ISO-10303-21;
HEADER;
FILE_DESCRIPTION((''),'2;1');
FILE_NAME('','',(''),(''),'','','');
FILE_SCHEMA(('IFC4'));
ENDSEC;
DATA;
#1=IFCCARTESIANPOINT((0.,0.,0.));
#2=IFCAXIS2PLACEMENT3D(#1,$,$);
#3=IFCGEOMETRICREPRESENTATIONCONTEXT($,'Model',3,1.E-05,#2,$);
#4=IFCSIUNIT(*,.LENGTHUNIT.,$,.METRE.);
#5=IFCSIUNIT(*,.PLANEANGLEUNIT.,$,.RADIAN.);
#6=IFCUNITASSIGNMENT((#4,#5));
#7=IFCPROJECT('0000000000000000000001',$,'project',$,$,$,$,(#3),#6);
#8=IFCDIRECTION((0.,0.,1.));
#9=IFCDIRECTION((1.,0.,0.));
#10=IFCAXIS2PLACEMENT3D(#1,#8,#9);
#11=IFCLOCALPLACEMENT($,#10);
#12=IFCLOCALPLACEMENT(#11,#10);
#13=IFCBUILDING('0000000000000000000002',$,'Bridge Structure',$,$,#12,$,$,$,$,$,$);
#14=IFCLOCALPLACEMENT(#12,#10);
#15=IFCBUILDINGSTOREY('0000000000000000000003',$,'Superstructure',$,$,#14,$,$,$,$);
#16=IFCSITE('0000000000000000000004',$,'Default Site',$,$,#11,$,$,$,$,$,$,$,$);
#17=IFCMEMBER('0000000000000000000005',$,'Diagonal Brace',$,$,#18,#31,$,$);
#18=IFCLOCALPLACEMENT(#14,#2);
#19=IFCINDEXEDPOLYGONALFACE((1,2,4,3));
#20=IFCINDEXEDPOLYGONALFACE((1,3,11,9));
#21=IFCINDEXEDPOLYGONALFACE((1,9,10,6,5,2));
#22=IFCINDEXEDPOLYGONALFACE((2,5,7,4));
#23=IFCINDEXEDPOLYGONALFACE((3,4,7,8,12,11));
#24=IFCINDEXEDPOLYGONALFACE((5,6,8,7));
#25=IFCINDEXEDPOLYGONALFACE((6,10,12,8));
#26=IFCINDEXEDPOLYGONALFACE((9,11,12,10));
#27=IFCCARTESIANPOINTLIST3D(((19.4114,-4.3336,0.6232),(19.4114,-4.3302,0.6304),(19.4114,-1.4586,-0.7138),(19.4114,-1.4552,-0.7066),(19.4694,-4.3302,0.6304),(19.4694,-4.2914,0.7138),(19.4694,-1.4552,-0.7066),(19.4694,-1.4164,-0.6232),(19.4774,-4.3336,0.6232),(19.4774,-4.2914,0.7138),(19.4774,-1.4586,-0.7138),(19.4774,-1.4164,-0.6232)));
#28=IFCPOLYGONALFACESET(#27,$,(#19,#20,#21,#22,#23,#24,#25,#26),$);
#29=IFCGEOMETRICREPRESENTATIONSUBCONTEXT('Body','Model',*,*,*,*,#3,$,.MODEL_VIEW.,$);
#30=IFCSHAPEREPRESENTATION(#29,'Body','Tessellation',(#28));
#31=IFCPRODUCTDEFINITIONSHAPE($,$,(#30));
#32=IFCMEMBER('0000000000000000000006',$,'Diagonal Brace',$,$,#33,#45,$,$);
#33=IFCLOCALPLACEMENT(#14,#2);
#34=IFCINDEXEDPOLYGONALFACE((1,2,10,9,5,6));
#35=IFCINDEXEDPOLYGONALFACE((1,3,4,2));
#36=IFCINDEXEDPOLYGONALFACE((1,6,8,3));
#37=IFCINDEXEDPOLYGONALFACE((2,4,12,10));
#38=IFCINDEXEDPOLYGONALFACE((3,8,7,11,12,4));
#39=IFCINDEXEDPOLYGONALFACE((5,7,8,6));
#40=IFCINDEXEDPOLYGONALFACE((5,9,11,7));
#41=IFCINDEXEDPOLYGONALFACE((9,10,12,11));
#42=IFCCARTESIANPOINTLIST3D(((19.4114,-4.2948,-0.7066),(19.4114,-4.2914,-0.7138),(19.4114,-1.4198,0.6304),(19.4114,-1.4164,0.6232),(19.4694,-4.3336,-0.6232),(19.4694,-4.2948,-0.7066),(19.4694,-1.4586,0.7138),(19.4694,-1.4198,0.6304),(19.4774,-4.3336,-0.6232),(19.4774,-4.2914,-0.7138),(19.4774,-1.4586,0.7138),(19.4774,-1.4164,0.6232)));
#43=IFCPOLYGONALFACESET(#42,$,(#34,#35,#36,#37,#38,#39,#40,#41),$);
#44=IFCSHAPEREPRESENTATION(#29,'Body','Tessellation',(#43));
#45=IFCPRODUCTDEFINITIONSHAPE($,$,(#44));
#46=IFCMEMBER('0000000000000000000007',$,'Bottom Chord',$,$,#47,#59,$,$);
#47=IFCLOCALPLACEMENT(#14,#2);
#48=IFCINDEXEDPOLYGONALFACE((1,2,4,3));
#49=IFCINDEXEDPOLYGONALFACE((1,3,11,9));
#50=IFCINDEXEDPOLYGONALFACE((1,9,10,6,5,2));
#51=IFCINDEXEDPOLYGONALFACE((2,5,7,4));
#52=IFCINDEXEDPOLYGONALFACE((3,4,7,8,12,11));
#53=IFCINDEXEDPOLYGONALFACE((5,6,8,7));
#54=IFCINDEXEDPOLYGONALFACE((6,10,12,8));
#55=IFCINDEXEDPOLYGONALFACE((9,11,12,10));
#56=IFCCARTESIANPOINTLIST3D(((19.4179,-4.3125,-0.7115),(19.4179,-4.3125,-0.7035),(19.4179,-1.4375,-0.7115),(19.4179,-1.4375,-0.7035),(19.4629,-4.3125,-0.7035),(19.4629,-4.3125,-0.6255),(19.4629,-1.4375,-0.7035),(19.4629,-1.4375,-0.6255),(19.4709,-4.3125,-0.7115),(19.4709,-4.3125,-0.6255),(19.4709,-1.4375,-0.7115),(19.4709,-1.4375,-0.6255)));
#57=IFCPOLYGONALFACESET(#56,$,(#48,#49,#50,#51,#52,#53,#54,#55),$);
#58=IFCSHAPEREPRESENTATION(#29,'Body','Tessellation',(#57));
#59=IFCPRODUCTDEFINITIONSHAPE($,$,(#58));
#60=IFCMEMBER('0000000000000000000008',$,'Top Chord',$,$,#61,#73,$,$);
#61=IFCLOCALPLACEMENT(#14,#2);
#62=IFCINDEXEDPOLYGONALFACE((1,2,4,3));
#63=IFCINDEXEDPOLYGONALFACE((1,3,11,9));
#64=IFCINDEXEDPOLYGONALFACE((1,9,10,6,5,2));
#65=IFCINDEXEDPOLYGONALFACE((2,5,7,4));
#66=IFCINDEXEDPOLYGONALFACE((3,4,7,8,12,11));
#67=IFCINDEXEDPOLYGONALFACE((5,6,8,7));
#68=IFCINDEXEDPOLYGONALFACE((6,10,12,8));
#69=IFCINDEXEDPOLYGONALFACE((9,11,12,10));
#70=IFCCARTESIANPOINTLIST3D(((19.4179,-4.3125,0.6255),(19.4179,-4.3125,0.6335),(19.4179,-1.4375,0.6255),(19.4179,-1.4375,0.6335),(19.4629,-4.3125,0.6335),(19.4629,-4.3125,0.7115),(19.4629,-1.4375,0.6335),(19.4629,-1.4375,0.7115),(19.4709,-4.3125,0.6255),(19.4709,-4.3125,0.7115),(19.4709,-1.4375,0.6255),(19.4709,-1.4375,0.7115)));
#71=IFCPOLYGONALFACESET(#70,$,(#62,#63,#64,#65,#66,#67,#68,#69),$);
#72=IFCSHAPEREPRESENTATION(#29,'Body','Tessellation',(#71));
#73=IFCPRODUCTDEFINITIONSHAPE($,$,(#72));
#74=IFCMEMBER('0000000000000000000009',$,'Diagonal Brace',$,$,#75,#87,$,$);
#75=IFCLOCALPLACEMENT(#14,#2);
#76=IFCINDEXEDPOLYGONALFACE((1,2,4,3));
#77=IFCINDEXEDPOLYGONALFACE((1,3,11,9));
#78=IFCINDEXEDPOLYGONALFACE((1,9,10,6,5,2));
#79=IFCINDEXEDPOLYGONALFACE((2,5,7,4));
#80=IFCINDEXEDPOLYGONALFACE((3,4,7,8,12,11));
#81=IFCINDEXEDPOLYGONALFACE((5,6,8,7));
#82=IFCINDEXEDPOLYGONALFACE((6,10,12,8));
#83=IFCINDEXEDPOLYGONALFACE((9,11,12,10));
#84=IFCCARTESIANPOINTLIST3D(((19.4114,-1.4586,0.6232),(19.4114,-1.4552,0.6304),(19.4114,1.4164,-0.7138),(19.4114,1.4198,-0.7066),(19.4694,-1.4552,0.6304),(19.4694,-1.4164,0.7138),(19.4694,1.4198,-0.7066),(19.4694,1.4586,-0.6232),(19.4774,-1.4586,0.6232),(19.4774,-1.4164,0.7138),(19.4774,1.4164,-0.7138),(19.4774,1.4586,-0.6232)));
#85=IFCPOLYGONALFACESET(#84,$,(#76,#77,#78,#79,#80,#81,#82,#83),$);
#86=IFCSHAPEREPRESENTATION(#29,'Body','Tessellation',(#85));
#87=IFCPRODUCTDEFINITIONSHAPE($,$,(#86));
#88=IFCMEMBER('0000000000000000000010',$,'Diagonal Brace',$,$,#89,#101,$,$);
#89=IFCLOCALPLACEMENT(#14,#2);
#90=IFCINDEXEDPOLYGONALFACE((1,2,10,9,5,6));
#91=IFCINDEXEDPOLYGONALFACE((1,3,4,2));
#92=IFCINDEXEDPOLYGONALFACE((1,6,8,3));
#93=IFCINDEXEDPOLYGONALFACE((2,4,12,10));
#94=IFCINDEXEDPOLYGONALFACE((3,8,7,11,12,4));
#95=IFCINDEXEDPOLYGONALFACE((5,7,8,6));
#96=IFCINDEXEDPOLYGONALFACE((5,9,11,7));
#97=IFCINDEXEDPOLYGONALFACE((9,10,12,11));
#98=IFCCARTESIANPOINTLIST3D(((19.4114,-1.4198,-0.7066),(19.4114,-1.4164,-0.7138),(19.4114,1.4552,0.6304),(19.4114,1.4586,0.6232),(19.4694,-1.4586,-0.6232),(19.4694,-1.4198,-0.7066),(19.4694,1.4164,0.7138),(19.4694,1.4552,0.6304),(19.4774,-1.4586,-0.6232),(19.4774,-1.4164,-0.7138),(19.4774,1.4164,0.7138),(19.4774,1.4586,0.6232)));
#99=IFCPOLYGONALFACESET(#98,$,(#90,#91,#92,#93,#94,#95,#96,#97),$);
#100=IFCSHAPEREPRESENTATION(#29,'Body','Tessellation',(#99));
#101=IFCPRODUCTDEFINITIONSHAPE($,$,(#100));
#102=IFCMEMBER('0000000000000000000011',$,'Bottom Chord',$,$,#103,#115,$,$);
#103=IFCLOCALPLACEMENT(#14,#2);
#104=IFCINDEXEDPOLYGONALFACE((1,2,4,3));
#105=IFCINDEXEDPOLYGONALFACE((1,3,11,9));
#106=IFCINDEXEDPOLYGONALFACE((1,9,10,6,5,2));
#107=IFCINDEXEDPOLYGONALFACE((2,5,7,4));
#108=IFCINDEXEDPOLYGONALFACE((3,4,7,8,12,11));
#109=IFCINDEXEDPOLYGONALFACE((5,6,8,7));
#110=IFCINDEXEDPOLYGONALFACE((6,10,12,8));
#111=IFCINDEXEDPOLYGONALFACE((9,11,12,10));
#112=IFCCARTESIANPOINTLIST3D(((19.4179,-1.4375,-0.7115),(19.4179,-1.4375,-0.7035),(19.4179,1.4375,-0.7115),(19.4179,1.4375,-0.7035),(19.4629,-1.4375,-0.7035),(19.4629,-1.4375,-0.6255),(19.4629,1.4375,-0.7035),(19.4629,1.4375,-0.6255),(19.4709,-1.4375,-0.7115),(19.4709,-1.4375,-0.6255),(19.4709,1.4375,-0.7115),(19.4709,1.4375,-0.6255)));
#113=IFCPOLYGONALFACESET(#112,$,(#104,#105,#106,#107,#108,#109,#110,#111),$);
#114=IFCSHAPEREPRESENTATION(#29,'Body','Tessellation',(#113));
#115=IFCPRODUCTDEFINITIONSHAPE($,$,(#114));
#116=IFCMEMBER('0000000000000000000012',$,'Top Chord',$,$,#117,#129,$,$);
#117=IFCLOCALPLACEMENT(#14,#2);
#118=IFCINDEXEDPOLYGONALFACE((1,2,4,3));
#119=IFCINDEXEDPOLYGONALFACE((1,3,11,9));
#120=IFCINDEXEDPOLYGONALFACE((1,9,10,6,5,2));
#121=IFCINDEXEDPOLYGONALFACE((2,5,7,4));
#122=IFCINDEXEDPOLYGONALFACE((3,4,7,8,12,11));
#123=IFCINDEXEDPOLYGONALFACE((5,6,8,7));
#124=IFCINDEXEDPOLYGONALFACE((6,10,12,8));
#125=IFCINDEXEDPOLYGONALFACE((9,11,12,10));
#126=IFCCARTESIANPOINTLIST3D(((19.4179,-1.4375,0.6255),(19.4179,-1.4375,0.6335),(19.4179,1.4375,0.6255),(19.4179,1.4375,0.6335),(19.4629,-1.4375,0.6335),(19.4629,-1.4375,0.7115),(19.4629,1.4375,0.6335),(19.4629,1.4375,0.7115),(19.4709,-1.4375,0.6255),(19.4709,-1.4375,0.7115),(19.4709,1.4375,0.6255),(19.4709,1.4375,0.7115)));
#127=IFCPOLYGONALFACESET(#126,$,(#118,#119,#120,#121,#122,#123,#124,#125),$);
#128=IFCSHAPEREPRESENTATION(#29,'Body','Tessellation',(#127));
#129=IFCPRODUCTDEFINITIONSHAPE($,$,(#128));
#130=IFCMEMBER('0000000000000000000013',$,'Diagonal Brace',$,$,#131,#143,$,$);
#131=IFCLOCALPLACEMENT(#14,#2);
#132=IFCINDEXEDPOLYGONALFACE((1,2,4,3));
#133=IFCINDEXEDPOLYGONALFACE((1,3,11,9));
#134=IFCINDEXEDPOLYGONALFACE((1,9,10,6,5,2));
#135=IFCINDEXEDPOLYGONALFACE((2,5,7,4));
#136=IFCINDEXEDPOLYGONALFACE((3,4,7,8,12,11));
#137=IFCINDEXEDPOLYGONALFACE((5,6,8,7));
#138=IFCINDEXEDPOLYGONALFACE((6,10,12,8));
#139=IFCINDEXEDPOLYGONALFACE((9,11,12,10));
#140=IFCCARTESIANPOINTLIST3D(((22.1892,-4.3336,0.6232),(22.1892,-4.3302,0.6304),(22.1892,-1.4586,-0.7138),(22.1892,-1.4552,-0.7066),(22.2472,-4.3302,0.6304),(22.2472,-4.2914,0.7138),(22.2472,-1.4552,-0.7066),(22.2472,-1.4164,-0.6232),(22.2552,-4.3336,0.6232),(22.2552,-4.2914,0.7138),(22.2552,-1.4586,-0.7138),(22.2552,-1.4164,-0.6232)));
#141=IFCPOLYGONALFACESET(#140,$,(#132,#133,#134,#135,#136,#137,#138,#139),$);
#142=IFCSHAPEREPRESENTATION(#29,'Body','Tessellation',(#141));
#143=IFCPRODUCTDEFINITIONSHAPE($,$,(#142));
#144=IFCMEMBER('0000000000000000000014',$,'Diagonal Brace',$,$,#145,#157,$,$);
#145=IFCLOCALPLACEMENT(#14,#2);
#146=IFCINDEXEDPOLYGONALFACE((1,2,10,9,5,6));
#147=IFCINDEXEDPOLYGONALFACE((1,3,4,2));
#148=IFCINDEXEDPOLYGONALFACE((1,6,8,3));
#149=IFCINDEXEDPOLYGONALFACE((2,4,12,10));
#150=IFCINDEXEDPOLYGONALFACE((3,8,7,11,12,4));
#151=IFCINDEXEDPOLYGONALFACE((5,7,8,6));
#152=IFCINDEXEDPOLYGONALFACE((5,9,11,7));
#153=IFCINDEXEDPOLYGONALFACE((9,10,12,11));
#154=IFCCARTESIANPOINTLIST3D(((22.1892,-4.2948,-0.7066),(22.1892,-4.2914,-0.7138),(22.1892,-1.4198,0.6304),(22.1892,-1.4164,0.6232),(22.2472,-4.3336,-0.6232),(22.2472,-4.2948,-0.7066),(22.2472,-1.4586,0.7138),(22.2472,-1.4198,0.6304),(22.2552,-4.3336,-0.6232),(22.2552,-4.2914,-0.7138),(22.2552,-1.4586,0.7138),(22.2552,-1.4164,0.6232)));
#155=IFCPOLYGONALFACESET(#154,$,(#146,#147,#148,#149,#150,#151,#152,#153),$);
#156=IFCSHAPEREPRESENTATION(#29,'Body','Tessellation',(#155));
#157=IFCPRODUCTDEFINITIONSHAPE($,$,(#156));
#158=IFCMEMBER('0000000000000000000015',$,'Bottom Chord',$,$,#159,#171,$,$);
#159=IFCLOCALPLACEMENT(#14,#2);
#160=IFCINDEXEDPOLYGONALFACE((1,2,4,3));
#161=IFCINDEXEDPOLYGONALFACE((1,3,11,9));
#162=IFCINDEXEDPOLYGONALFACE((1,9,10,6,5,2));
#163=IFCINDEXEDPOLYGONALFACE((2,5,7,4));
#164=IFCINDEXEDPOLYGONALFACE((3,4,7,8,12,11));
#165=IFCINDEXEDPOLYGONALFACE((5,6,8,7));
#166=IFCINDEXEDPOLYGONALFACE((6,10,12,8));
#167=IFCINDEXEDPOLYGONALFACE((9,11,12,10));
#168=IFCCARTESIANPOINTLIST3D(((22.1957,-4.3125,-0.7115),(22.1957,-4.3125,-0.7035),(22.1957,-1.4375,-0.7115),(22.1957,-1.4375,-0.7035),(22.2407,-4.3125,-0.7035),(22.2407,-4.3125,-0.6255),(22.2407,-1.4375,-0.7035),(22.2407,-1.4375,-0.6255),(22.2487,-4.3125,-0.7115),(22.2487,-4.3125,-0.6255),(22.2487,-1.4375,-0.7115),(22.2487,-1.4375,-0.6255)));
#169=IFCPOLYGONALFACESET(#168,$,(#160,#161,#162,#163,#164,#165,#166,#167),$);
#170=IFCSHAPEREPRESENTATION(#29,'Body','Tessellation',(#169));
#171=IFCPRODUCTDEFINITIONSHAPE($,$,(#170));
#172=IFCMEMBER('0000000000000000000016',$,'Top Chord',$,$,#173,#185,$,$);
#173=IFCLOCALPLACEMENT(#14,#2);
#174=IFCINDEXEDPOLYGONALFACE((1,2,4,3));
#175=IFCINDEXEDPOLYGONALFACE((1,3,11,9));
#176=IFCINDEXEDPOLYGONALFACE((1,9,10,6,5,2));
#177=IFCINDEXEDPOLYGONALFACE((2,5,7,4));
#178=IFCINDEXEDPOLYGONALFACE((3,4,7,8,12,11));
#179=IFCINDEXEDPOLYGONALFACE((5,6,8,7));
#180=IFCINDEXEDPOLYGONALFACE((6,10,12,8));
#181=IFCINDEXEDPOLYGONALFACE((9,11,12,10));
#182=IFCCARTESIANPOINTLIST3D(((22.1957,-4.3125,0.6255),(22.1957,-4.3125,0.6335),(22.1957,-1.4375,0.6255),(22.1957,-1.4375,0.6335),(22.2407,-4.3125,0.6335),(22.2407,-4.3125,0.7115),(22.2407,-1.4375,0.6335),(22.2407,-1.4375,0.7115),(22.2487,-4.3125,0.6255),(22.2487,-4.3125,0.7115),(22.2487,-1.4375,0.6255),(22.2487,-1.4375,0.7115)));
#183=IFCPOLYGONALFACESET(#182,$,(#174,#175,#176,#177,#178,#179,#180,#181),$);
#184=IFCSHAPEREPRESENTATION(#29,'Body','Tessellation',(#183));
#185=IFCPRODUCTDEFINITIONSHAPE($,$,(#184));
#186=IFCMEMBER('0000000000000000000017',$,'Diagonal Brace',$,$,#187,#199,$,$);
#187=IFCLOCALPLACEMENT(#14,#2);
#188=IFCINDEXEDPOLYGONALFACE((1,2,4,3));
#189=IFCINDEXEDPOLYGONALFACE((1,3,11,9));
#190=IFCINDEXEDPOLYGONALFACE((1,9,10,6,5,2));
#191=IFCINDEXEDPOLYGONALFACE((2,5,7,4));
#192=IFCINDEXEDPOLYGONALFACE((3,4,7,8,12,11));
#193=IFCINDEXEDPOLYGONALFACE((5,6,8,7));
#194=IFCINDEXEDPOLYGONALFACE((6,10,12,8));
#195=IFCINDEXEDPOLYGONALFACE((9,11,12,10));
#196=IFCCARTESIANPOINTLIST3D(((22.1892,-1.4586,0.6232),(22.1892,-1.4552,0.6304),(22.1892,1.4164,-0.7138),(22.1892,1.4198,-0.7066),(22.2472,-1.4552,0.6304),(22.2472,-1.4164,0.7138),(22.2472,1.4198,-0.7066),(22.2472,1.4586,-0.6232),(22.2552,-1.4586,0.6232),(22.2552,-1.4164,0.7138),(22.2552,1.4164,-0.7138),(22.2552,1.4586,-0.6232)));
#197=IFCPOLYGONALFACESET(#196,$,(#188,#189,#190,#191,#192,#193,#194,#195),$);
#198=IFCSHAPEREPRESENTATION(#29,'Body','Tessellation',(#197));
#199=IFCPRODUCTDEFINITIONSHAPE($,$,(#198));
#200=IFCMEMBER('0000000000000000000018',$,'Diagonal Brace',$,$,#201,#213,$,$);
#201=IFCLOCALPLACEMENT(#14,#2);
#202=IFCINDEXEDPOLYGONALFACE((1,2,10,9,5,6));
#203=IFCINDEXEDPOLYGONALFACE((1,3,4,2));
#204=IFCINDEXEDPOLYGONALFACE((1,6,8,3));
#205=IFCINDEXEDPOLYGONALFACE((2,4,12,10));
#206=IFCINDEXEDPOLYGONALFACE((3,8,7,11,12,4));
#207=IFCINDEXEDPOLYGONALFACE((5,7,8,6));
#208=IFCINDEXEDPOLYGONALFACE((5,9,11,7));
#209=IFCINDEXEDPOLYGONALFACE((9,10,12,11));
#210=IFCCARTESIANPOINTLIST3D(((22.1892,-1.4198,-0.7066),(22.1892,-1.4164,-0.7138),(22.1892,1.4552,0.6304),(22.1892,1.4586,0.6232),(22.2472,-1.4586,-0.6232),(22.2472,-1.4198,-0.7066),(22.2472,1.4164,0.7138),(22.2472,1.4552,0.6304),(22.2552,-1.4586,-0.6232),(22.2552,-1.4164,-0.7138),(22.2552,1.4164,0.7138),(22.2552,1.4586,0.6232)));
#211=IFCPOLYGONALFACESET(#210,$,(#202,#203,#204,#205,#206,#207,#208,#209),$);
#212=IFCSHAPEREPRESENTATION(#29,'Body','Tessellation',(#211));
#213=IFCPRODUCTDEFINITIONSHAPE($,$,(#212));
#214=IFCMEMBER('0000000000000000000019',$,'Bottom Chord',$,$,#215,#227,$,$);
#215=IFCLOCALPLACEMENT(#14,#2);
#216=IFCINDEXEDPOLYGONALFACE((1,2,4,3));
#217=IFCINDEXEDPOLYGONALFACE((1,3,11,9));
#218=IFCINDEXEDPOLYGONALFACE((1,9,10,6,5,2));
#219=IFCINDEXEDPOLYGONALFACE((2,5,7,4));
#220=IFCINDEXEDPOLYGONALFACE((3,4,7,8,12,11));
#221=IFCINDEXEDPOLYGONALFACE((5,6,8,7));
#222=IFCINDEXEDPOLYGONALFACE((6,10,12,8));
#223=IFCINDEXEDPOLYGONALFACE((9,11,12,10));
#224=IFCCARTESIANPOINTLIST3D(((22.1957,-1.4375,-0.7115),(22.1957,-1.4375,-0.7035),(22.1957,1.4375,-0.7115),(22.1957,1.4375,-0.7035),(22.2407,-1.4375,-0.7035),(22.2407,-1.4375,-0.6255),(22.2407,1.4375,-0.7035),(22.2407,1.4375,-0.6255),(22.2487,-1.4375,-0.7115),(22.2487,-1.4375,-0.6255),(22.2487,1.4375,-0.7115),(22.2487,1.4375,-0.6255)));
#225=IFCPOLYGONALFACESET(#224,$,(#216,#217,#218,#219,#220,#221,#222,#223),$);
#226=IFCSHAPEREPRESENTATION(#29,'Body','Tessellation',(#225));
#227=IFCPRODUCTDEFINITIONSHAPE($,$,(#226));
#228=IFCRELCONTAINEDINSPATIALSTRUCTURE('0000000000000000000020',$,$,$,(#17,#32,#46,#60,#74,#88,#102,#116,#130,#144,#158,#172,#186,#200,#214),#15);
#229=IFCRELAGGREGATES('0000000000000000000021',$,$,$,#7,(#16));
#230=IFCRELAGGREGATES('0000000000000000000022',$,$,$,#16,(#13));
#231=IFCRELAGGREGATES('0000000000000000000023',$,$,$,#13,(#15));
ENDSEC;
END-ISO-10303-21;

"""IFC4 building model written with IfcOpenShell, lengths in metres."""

from ifc_helpers import new_model, si_unit, frame, origin, origin_with_axes, origin_2d_with_axis, place, context, subcontext, project, spatial, l_section, extrude, element, save


model = new_model("IFC4")

# Units and contexts
model_context = context("Model", 3, precision=1e-05, world=origin())
body_context = subcontext(model_context, "Body", "Model", "MODEL_VIEW")
ifc_project = project(units=[si_unit("LENGTHUNIT", "METRE"), si_unit("PLANEANGLEUNIT", "RADIAN")], contexts=[model_context])

# Site, building, storey
site_placement = place(None, origin_with_axes())
site = spatial("IfcSite", under=ifc_project, at=site_placement, Name="Default Site")
building_placement = place(site_placement, origin_with_axes())
building = spatial("IfcBuilding", under=site, at=building_placement, Name="Bridge Structure")
storey_placement = place(building_placement, origin_with_axes())
storey = spatial("IfcBuildingStorey", under=building, at=storey_placement, Name="Superstructure")

# Members
for number, where, z_axis, x_axis, name in (
    (1, (19.4444, -4.3125, 0.6685), (0.0, 0.906746, -0.421676), (-1.0, 0.0, 0.0), "Diagonal Brace"),
    (2, (19.4444, -4.3125, -0.6685), (0.0, 0.906746, 0.421676), (-1.0, 0.0, 0.0), "Diagonal Brace"),
):
    element("IfcMember", number, at=place(storey_placement, frame(where, z_axis=z_axis, x_axis=x_axis)), inside=storey, Name=name, context=body_context, shape_type="SweptSolid", body=[
        extrude(l_section(Depth=0.1, Width=0.066, Thickness=0.008, at=origin_2d_with_axis()), origin_with_axes(), (0.0, 0.0, 1.0), 3.1707),
    ])
for number, where, z_axis, x_axis, name in (
    (3, (19.4444, -4.3125, -0.6685), (0.0, 1.0, 0.0), (-1.0, 0.0, 0.0), "Bottom Chord"),
    (4, (19.4444, -4.3125, 0.6685), (0.0, 1.0, 0.0), (-1.0, 0.0, 0.0), "Top Chord"),
):
    element("IfcMember", number, at=place(storey_placement, frame(where, z_axis=z_axis, x_axis=x_axis)), inside=storey, Name=name, context=body_context, shape_type="SweptSolid", body=[
        extrude(l_section(Depth=0.086, Width=0.053, Thickness=0.008, at=origin_2d_with_axis()), origin_with_axes(), (0.0, 0.0, 1.0), 2.875),
    ])
for number, where, z_axis, x_axis, name in (
    (5, (19.4444, -1.4375, 0.6685), (0.0, 0.906746, -0.421676), (-1.0, 0.0, 0.0), "Diagonal Brace"),
    (6, (19.4444, -1.4375, -0.6685), (0.0, 0.906746, 0.421676), (-1.0, 0.0, 0.0), "Diagonal Brace"),
):
    element("IfcMember", number, at=place(storey_placement, frame(where, z_axis=z_axis, x_axis=x_axis)), inside=storey, Name=name, context=body_context, shape_type="SweptSolid", body=[
        extrude(l_section(Depth=0.1, Width=0.066, Thickness=0.008, at=origin_2d_with_axis()), origin_with_axes(), (0.0, 0.0, 1.0), 3.1707),
    ])
for number, where, z_axis, x_axis, name in (
    (7, (19.4444, -1.4375, -0.6685), (0.0, 1.0, 0.0), (-1.0, 0.0, 0.0), "Bottom Chord"),
    (8, (19.4444, -1.4375, 0.6685), (0.0, 1.0, 0.0), (-1.0, 0.0, 0.0), "Top Chord"),
):
    element("IfcMember", number, at=place(storey_placement, frame(where, z_axis=z_axis, x_axis=x_axis)), inside=storey, Name=name, context=body_context, shape_type="SweptSolid", body=[
        extrude(l_section(Depth=0.086, Width=0.053, Thickness=0.008, at=origin_2d_with_axis()), origin_with_axes(), (0.0, 0.0, 1.0), 2.875),
    ])
for number, where, z_axis, x_axis, name in (
    (9, (22.2222, -4.3125, 0.6685), (0.0, 0.906746, -0.421676), (-1.0, 0.0, 0.0), "Diagonal Brace"),
    (10, (22.2222, -4.3125, -0.6685), (0.0, 0.906746, 0.421676), (-1.0, 0.0, 0.0), "Diagonal Brace"),
):
    element("IfcMember", number, at=place(storey_placement, frame(where, z_axis=z_axis, x_axis=x_axis)), inside=storey, Name=name, context=body_context, shape_type="SweptSolid", body=[
        extrude(l_section(Depth=0.1, Width=0.066, Thickness=0.008, at=origin_2d_with_axis()), origin_with_axes(), (0.0, 0.0, 1.0), 3.1707),
    ])
for number, where, z_axis, x_axis, name in (
    (11, (22.2222, -4.3125, -0.6685), (0.0, 1.0, 0.0), (-1.0, 0.0, 0.0), "Bottom Chord"),
    (12, (22.2222, -4.3125, 0.6685), (0.0, 1.0, 0.0), (-1.0, 0.0, 0.0), "Top Chord"),
):
    element("IfcMember", number, at=place(storey_placement, frame(where, z_axis=z_axis, x_axis=x_axis)), inside=storey, Name=name, context=body_context, shape_type="SweptSolid", body=[
        extrude(l_section(Depth=0.086, Width=0.053, Thickness=0.008, at=origin_2d_with_axis()), origin_with_axes(), (0.0, 0.0, 1.0), 2.875),
    ])
for number, where, z_axis, x_axis, name in (
    (13, (22.2222, -1.4375, 0.6685), (0.0, 0.906746, -0.421676), (-1.0, 0.0, 0.0), "Diagonal Brace"),
    (14, (22.2222, -1.4375, -0.6685), (0.0, 0.906746, 0.421676), (-1.0, 0.0, 0.0), "Diagonal Brace"),
):
    element("IfcMember", number, at=place(storey_placement, frame(where, z_axis=z_axis, x_axis=x_axis)), inside=storey, Name=name, context=body_context, shape_type="SweptSolid", body=[
        extrude(l_section(Depth=0.1, Width=0.066, Thickness=0.008, at=origin_2d_with_axis()), origin_with_axes(), (0.0, 0.0, 1.0), 3.1707),
    ])
for number, where, z_axis, x_axis, name in (
    (15, (22.2222, -1.4375, -0.6685), (0.0, 1.0, 0.0), (-1.0, 0.0, 0.0), "Bottom Chord"),
):
    element("IfcMember", number, at=place(storey_placement, frame(where, z_axis=z_axis, x_axis=x_axis)), inside=storey, Name=name, context=body_context, shape_type="SweptSolid", body=[
        extrude(l_section(Depth=0.086, Width=0.053, Thickness=0.008, at=origin_2d_with_axis()), origin_with_axes(), (0.0, 0.0, 1.0), 2.875),
    ])

save(model, "model.ifc")
